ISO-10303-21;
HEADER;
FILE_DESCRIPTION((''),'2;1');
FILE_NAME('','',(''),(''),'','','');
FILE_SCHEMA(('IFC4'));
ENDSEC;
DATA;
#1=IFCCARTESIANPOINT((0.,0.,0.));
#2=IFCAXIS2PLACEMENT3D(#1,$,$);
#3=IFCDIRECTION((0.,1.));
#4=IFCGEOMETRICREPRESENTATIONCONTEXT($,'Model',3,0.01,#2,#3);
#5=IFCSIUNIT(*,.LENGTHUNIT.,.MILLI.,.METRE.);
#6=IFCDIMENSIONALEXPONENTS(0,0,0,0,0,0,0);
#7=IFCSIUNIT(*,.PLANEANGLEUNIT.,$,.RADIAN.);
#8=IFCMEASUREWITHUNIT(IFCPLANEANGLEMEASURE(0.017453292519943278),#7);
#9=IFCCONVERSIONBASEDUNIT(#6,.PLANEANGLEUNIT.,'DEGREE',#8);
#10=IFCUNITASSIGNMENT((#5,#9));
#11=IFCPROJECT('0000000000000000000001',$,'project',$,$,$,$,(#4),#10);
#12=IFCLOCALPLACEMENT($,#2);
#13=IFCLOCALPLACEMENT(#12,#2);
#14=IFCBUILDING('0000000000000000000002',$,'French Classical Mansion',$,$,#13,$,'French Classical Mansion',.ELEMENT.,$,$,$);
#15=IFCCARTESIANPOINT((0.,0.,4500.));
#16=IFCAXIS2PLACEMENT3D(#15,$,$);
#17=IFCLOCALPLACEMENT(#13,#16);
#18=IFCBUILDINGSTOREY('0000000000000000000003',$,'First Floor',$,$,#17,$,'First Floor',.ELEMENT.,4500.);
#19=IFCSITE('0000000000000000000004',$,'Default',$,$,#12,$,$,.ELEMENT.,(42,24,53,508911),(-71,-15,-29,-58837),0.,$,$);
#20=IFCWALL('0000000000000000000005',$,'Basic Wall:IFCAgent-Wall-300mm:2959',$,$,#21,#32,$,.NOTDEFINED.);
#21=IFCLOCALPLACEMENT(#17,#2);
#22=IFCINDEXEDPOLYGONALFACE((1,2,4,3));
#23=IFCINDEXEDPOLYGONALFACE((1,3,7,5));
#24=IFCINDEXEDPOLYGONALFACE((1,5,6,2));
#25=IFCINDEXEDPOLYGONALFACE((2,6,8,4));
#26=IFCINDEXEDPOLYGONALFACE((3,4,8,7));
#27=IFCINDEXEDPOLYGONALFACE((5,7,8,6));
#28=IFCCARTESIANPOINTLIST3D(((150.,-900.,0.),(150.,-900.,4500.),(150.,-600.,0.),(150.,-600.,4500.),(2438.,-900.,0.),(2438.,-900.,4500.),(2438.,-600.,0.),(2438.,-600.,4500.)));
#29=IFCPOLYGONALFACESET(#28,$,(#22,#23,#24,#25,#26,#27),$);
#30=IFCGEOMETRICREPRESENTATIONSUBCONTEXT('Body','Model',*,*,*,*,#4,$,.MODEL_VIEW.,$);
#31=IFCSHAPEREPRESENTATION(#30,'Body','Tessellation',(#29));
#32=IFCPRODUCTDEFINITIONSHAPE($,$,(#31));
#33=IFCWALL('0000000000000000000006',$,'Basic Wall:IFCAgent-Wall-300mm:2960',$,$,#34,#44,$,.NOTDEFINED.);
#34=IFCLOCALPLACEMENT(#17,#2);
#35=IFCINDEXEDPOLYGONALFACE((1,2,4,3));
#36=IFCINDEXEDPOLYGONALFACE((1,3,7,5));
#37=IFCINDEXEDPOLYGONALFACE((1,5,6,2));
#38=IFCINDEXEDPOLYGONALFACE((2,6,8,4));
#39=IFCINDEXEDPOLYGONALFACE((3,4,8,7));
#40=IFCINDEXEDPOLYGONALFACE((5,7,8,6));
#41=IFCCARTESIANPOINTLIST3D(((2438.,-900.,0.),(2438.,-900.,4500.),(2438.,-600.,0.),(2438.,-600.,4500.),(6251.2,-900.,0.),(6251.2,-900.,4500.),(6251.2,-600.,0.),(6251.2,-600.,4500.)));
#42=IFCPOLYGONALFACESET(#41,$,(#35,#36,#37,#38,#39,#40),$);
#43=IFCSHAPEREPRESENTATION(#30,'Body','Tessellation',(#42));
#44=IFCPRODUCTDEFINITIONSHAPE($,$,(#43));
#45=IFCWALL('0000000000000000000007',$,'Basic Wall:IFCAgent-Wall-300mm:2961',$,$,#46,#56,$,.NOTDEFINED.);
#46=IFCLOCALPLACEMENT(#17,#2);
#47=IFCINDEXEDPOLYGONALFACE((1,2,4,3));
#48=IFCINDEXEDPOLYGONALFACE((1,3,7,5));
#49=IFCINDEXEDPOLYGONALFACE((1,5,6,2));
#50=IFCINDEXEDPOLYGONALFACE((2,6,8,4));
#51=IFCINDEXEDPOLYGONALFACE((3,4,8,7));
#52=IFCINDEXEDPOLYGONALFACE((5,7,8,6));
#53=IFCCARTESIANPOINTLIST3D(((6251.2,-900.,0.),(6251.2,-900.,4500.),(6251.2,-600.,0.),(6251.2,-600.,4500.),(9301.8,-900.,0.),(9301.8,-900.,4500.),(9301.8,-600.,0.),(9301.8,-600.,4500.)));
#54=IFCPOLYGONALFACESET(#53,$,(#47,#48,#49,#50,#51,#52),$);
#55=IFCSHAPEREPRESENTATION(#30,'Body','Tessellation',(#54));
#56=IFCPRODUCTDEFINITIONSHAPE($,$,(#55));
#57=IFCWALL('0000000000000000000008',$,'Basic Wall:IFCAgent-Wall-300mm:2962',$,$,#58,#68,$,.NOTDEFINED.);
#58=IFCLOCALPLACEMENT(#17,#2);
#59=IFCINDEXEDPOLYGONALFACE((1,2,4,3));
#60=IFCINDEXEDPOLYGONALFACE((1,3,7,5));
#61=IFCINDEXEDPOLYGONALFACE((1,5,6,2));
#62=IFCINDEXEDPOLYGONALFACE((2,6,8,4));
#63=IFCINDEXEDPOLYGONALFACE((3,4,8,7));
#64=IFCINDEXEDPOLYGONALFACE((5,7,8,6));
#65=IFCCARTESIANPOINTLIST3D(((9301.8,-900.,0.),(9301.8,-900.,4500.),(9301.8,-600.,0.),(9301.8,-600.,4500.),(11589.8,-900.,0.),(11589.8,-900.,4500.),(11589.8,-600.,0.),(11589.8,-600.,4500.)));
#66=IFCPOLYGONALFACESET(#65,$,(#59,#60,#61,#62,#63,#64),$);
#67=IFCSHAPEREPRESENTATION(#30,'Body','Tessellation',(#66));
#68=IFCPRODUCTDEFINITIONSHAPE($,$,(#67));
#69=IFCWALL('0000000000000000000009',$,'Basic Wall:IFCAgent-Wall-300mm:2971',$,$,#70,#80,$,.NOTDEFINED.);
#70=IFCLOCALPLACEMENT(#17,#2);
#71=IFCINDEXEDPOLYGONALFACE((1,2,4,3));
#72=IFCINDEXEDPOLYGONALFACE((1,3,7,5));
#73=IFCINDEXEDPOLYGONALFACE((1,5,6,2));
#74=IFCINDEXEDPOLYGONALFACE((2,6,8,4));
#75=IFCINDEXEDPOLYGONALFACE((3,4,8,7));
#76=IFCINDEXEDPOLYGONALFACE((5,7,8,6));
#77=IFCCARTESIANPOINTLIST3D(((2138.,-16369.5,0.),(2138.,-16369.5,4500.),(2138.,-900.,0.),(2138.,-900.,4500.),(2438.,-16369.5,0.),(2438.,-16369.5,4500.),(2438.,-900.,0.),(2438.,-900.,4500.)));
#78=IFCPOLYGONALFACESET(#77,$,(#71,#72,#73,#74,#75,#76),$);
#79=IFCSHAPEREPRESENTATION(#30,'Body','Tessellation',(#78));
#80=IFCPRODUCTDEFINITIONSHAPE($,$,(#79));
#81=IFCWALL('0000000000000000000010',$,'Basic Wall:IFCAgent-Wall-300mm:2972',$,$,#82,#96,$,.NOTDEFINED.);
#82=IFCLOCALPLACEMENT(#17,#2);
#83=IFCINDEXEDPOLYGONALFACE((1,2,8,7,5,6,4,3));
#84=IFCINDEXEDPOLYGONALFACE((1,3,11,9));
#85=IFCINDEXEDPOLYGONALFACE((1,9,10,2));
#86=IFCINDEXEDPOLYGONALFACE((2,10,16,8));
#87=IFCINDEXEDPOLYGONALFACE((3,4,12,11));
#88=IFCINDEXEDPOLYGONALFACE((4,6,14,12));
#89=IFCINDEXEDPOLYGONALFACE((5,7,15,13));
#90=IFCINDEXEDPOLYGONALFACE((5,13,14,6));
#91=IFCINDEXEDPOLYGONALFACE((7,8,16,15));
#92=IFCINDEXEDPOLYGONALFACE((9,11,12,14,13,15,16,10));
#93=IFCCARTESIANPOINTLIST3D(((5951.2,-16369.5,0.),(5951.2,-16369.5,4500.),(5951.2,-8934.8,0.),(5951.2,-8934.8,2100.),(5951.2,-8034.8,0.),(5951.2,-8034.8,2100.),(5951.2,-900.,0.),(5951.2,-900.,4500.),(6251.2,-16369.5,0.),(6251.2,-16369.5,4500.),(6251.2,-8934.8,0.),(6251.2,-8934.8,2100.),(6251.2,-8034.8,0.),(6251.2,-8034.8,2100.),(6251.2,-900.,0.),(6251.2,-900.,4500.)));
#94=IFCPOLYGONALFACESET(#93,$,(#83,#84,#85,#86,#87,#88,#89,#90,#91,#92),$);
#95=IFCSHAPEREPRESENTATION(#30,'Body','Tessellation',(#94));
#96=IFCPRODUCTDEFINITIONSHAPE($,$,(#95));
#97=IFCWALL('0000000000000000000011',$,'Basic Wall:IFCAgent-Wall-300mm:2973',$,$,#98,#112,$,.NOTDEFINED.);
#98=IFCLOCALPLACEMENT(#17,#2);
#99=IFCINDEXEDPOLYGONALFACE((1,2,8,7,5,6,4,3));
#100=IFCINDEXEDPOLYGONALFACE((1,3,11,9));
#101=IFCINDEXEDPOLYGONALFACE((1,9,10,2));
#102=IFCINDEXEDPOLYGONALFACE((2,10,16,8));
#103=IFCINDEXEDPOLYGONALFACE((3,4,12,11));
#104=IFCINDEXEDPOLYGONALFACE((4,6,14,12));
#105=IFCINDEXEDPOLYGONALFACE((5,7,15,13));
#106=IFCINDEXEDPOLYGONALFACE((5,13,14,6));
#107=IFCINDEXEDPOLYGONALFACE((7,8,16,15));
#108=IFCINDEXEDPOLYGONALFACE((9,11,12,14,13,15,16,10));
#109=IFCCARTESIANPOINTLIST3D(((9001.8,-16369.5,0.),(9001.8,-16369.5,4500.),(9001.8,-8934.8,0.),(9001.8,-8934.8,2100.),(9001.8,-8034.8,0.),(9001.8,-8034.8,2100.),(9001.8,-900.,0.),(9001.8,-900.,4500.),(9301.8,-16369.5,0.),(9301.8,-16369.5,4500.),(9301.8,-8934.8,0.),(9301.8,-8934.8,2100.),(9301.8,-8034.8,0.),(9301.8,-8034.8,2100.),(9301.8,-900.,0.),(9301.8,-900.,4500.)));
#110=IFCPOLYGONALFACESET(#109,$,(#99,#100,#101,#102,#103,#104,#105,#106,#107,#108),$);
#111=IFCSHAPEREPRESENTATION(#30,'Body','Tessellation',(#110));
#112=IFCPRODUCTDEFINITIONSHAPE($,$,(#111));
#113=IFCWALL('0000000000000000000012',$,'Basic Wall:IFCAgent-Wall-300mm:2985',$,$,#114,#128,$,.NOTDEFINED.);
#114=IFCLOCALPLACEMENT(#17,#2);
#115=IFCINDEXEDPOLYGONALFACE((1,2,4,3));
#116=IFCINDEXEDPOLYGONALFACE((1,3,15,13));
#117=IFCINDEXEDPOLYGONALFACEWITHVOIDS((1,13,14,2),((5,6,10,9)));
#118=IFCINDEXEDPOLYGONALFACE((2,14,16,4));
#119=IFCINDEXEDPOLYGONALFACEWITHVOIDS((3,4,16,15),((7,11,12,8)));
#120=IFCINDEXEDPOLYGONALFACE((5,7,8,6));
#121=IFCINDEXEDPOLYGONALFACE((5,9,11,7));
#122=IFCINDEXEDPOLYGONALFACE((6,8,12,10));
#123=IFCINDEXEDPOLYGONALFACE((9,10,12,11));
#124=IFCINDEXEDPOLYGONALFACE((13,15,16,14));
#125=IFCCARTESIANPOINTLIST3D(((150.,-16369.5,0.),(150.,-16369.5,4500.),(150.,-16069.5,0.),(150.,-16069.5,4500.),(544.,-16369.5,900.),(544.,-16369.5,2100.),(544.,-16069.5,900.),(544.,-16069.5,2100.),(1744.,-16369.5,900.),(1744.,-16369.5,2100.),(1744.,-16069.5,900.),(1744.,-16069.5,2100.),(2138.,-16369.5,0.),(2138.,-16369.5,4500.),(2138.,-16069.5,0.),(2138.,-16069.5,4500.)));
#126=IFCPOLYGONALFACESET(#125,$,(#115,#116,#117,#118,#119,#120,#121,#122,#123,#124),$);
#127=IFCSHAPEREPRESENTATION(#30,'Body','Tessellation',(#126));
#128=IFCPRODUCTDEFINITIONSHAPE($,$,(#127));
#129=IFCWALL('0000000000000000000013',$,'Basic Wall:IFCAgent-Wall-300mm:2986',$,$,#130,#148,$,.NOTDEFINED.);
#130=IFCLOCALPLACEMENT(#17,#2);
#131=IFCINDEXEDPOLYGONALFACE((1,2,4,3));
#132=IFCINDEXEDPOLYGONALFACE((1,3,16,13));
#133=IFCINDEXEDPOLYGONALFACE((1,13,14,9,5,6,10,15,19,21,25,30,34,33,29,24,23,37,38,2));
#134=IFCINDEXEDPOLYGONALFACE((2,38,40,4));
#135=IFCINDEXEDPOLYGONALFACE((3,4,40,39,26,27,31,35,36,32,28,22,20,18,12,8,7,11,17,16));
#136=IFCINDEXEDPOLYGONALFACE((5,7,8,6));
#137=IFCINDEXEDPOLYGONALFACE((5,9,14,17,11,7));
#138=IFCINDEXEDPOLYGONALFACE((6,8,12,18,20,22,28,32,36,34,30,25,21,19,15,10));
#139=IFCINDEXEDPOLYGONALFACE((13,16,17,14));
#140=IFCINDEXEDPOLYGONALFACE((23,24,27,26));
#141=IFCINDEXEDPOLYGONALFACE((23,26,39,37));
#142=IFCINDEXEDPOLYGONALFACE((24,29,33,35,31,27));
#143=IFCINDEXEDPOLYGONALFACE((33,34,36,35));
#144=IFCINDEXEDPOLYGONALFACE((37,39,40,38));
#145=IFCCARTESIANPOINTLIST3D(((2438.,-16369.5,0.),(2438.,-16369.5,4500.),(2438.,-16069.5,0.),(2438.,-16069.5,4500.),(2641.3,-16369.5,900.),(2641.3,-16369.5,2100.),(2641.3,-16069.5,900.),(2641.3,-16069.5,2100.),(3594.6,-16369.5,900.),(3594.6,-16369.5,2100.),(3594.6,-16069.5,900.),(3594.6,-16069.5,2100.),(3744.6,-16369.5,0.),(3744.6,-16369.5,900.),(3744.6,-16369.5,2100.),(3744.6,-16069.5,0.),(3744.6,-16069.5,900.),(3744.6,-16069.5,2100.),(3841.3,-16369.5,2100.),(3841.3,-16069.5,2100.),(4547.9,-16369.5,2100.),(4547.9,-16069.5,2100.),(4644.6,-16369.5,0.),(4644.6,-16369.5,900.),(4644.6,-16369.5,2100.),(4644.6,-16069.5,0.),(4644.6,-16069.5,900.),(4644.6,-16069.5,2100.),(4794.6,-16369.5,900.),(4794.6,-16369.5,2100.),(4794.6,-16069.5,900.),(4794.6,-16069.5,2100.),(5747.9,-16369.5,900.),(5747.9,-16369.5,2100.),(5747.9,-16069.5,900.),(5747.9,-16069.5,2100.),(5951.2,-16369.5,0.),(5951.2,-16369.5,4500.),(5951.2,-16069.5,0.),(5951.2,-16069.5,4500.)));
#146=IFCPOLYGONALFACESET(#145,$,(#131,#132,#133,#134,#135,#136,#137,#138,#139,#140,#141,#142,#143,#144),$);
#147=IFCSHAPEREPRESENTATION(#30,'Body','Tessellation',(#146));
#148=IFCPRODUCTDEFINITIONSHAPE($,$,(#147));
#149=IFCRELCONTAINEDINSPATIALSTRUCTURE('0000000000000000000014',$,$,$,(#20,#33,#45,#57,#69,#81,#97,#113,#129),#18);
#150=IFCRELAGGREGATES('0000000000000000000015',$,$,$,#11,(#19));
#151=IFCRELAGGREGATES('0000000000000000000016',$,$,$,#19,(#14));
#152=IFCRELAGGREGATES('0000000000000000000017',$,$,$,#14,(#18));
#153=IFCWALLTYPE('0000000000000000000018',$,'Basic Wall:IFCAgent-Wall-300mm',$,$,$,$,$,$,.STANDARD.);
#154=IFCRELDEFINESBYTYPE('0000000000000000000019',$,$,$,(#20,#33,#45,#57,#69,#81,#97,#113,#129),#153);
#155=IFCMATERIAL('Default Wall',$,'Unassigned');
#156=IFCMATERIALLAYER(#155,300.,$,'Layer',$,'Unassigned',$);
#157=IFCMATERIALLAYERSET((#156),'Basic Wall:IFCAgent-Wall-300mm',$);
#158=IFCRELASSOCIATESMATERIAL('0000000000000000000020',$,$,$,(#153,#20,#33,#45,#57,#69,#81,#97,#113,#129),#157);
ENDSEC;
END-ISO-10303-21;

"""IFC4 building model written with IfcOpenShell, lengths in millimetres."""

from ifc_helpers import new_model, entity, si_unit, converted_unit, direction, frame, frame_2d, origin, place, context, subcontext, project, spatial, rectangle, extrude, material, layer, layer_set, layer_usage, type_object, element, save


model = new_model("IFC4")

# Units and contexts
model_context = context("Model", 3, precision=0.01, world=origin(), true_north=direction((0.0, 1.0)))
body_context = subcontext(model_context, "Body", "Model", "MODEL_VIEW")
ifc_project = project(units=[si_unit("LENGTHUNIT", "METRE", prefix="MILLI"), converted_unit("PLANEANGLEUNIT", "DEGREE", entity("IfcPlaneAngleMeasure", 0.017453292519943278), si_unit("PLANEANGLEUNIT", "RADIAN"), dimensions=[0, 0, 0, 0, 0, 0, 0])], contexts=[model_context])

# Site, building, storey
site_placement = place(None, origin())
site = spatial("IfcSite", under=ifc_project, at=site_placement, Name="Default", CompositionType="ELEMENT", RefLatitude=(42, 24, 53, 508911), RefLongitude=(-71, -15, -29, -58837), RefElevation=0.0)
building_placement = place(site_placement, origin())
building = spatial("IfcBuilding", under=site, at=building_placement, Name="French Classical Mansion", LongName="French Classical Mansion", CompositionType="ELEMENT")
storey_placement = place(building_placement, frame((0.0, 0.0, 4500.0)))
storey = spatial("IfcBuildingStorey", under=building, at=storey_placement, Name="First Floor", LongName="First Floor", CompositionType="ELEMENT", Elevation=4500.0)

# Walls
ifc_material = material(Name="Default Wall", Category="Unassigned")
ifc_layer = layer(ifc_material, 300.0, Name="Layer", Category="Unassigned")
ifc_layer_set = layer_set([ifc_layer], Name="Basic Wall:IFCAgent-Wall-300mm")
ifc_layer_usage_1 = layer_usage(ifc_layer_set, "AXIS2", "NEGATIVE", 150.0)
wall_type = type_object("IfcWallType", Name="Basic Wall:IFCAgent-Wall-300mm", PredefinedType="STANDARD", material=ifc_layer_set)
wall_1_placement = place(storey_placement, frame((150.0, -750.0, 0.0)))
element("IfcWall", 1, at=wall_1_placement, inside=storey, type_object=wall_type, material=ifc_layer_usage_1, Name="Basic Wall:IFCAgent-Wall-300mm:2959", PredefinedType="NOTDEFINED", context=body_context, shape_type="SweptSolid", body=[
    extrude(rectangle(XDim=2288.0, YDim=300.0, at=frame_2d((1144.0, 0.0), x_axis=(-1.0, 0.0))), origin(), (0.0, 0.0, 1.0), 4500.0),
])
ifc_layer_usage_2 = layer_usage(ifc_layer_set, "AXIS2", "NEGATIVE", 150.0)
wall_2_placement = place(storey_placement, frame((2438.0, -750.0, 0.0)))
element("IfcWall", 2, at=wall_2_placement, inside=storey, type_object=wall_type, material=ifc_layer_usage_2, Name="Basic Wall:IFCAgent-Wall-300mm:2960", PredefinedType="NOTDEFINED", context=body_context, shape_type="SweptSolid", body=[
    extrude(rectangle(XDim=3813.3, YDim=300.0, at=frame_2d((1906.6, 0.0), x_axis=(-1.0, 0.0))), origin(), (0.0, 0.0, 1.0), 4500.0),
])
ifc_layer_usage_3 = layer_usage(ifc_layer_set, "AXIS2", "NEGATIVE", 150.0)
wall_3_placement = place(storey_placement, frame((6251.2, -750.0, 0.0)))
element("IfcWall", 3, at=wall_3_placement, inside=storey, type_object=wall_type, material=ifc_layer_usage_3, Name="Basic Wall:IFCAgent-Wall-300mm:2961", PredefinedType="NOTDEFINED", context=body_context, shape_type="SweptSolid", body=[
    extrude(rectangle(XDim=3050.6, YDim=300.0, at=frame_2d((1525.3, 0.0), x_axis=(-1.0, 0.0))), origin(), (0.0, 0.0, 1.0), 4500.0),
])
ifc_layer_usage_4 = layer_usage(ifc_layer_set, "AXIS2", "NEGATIVE", 150.0)
wall_4_placement = place(storey_placement, frame((9301.8, -750.0, 0.0)))
element("IfcWall", 4, at=wall_4_placement, inside=storey, type_object=wall_type, material=ifc_layer_usage_4, Name="Basic Wall:IFCAgent-Wall-300mm:2962", PredefinedType="NOTDEFINED", context=body_context, shape_type="SweptSolid", body=[
    extrude(rectangle(XDim=2288.0, YDim=300.0, at=frame_2d((1144.0, 0.0), x_axis=(-1.0, 0.0))), origin(), (0.0, 0.0, 1.0), 4500.0),
])
ifc_layer_usage_5 = layer_usage(ifc_layer_set, "AXIS2", "NEGATIVE", 150.0)
wall_5_placement = place(storey_placement, frame((2288.0, -16369.5, 0.0), z_axis=(0.0, 0.0, 1.0), x_axis=(0.0, 1.0, 0.0)))
element("IfcWall", 5, at=wall_5_placement, inside=storey, type_object=wall_type, material=ifc_layer_usage_5, Name="Basic Wall:IFCAgent-Wall-300mm:2971", PredefinedType="NOTDEFINED", context=body_context, shape_type="SweptSolid", body=[
    extrude(rectangle(XDim=15469.5, YDim=300.0, at=frame_2d((7734.8, 0.0), x_axis=(-1.0, 0.0))), origin(), (0.0, 0.0, 1.0), 4500.0),
])

# Walls, openings
ifc_layer_usage_6 = layer_usage(ifc_layer_set, "AXIS2", "NEGATIVE", 150.0)
wall_6_placement = place(storey_placement, frame((6101.2, -16369.5, 0.0), z_axis=(0.0, 0.0, 1.0), x_axis=(0.0, 1.0, 0.0)))
wall_6 = element("IfcWall", 6, at=wall_6_placement, inside=storey, type_object=wall_type, material=ifc_layer_usage_6, Name="Basic Wall:IFCAgent-Wall-300mm:2972", PredefinedType="NOTDEFINED", context=body_context, shape_type="SweptSolid", body=[
    extrude(rectangle(XDim=15469.5, YDim=300.0, at=frame_2d((7734.8, 0.0), x_axis=(1.0, 0.0))), origin(), (0.0, 0.0, 1.0), 4500.0),
])
opening_1_placement = place(wall_6_placement, origin())
element("IfcOpeningElement", 7, at=opening_1_placement, cuts=wall_6, PredefinedType="OPENING", context=body_context, shape_type="SweptSolid", body=[
    extrude(rectangle(XDim=2100.0, YDim=900.0, at=frame_2d((0.0, 0.0), x_axis=(1.0, 0.0))), frame((7884.7, -150.0, 1050.0), z_axis=(0.0, 1.0, 0.0), x_axis=(0.0, 0.0, -1.0)), (0.0, 0.0, 1.0), 300.0),
])
ifc_layer_usage_7 = layer_usage(ifc_layer_set, "AXIS2", "NEGATIVE", 150.0)
wall_7_placement = place(storey_placement, frame((9151.8, -16369.5, 0.0), z_axis=(0.0, 0.0, 1.0), x_axis=(0.0, 1.0, 0.0)))
wall_7 = element("IfcWall", 8, at=wall_7_placement, inside=storey, type_object=wall_type, material=ifc_layer_usage_7, Name="Basic Wall:IFCAgent-Wall-300mm:2973", PredefinedType="NOTDEFINED", context=body_context, shape_type="SweptSolid", body=[
    extrude(rectangle(XDim=15469.5, YDim=300.0, at=frame_2d((7734.8, 0.0), x_axis=(1.0, 0.0))), origin(), (0.0, 0.0, 1.0), 4500.0),
])
opening_2_placement = place(wall_7_placement, origin())
element("IfcOpeningElement", 9, at=opening_2_placement, cuts=wall_7, PredefinedType="OPENING", context=body_context, shape_type="SweptSolid", body=[
    extrude(rectangle(XDim=2100.0, YDim=900.0, at=frame_2d((0.0, 0.0), x_axis=(1.0, 0.0))), frame((7884.7, -150.0, 1050.0), z_axis=(0.0, 1.0, 0.0), x_axis=(0.0, 0.0, -1.0)), (0.0, 0.0, 1.0), 300.0),
])
ifc_layer_usage_8 = layer_usage(ifc_layer_set, "AXIS2", "NEGATIVE", 150.0)
wall_8_placement = place(storey_placement, frame((150.0, -16219.5, 0.0)))
wall_8 = element("IfcWall", 10, at=wall_8_placement, inside=storey, type_object=wall_type, material=ifc_layer_usage_8, Name="Basic Wall:IFCAgent-Wall-300mm:2985", PredefinedType="NOTDEFINED", context=body_context, shape_type="SweptSolid", body=[
    extrude(rectangle(XDim=1988.0, YDim=300.0, at=frame_2d((994.0, 0.0), x_axis=(-1.0, 0.0))), origin(), (0.0, 0.0, 1.0), 4500.0),
])
opening_3_placement = place(wall_8_placement, origin())
element("IfcOpeningElement", 11, at=opening_3_placement, cuts=wall_8, PredefinedType="OPENING", context=body_context, shape_type="SweptSolid", body=[
    extrude(rectangle(XDim=1200.0, YDim=1200.0, at=frame_2d((0.0, 0.0), x_axis=(1.0, 0.0))), frame((994.0, -150.0, 1500.0), z_axis=(0.0, 1.0, 0.0), x_axis=(0.0, 0.0, -1.0)), (0.0, 0.0, 1.0), 300.0),
])

# Wall, openings
ifc_layer_usage_9 = layer_usage(ifc_layer_set, "AXIS2", "NEGATIVE", 150.0)
wall_9_placement = place(storey_placement, frame((2438.0, -16219.5, 0.0)))
wall_9 = element("IfcWall", 12, at=wall_9_placement, inside=storey, type_object=wall_type, material=ifc_layer_usage_9, Name="Basic Wall:IFCAgent-Wall-300mm:2986", PredefinedType="NOTDEFINED", context=body_context, shape_type="SweptSolid", body=[
    extrude(rectangle(XDim=3513.3, YDim=300.0, at=frame_2d((1756.6, 0.0), x_axis=(-1.0, 0.0))), origin(), (0.0, 0.0, 1.0), 4500.0),
])
opening_4_placement = place(wall_9_placement, origin())
element("IfcOpeningElement", 13, at=opening_4_placement, cuts=wall_9, PredefinedType="OPENING", context=body_context, shape_type="SweptSolid", body=[
    extrude(rectangle(XDim=2100.0, YDim=900.0, at=frame_2d((0.0, 0.0), x_axis=(1.0, 0.0))), frame((1756.6, -150.0, 1050.0), z_axis=(0.0, 1.0, 0.0), x_axis=(0.0, 0.0, -1.0)), (0.0, 0.0, 1.0), 300.0),
])
opening_5_placement = place(wall_9_placement, origin())
element("IfcOpeningElement", 14, at=opening_5_placement, cuts=wall_9, PredefinedType="OPENING", context=body_context, shape_type="SweptSolid", body=[
    extrude(rectangle(XDim=1200.0, YDim=1200.0, at=frame_2d((0.0, 0.0), x_axis=(1.0, 0.0))), frame((803.3, -150.0, 1500.0), z_axis=(0.0, 1.0, 0.0), x_axis=(0.0, 0.0, -1.0)), (0.0, 0.0, 1.0), 300.0),
])
opening_6_placement = place(wall_9_placement, origin())
element("IfcOpeningElement", 15, at=opening_6_placement, cuts=wall_9, PredefinedType="OPENING", context=body_context, shape_type="SweptSolid", body=[
    extrude(rectangle(XDim=1200.0, YDim=1200.0, at=frame_2d((0.0, 0.0), x_axis=(1.0, 0.0))), frame((1756.6, -150.0, 1500.0), z_axis=(0.0, 1.0, 0.0), x_axis=(0.0, 0.0, -1.0)), (0.0, 0.0, 1.0), 300.0),
])
opening_7_placement = place(wall_9_placement, origin())
element("IfcOpeningElement", 16, at=opening_7_placement, cuts=wall_9, PredefinedType="OPENING", context=body_context, shape_type="SweptSolid", body=[
    extrude(rectangle(XDim=1200.0, YDim=1200.0, at=frame_2d((0.0, 0.0), x_axis=(1.0, 0.0))), frame((2709.9, -150.0, 1500.0), z_axis=(0.0, 1.0, 0.0), x_axis=(0.0, 0.0, -1.0)), (0.0, 0.0, 1.0), 300.0),
])

save(model, "model.ifc")
